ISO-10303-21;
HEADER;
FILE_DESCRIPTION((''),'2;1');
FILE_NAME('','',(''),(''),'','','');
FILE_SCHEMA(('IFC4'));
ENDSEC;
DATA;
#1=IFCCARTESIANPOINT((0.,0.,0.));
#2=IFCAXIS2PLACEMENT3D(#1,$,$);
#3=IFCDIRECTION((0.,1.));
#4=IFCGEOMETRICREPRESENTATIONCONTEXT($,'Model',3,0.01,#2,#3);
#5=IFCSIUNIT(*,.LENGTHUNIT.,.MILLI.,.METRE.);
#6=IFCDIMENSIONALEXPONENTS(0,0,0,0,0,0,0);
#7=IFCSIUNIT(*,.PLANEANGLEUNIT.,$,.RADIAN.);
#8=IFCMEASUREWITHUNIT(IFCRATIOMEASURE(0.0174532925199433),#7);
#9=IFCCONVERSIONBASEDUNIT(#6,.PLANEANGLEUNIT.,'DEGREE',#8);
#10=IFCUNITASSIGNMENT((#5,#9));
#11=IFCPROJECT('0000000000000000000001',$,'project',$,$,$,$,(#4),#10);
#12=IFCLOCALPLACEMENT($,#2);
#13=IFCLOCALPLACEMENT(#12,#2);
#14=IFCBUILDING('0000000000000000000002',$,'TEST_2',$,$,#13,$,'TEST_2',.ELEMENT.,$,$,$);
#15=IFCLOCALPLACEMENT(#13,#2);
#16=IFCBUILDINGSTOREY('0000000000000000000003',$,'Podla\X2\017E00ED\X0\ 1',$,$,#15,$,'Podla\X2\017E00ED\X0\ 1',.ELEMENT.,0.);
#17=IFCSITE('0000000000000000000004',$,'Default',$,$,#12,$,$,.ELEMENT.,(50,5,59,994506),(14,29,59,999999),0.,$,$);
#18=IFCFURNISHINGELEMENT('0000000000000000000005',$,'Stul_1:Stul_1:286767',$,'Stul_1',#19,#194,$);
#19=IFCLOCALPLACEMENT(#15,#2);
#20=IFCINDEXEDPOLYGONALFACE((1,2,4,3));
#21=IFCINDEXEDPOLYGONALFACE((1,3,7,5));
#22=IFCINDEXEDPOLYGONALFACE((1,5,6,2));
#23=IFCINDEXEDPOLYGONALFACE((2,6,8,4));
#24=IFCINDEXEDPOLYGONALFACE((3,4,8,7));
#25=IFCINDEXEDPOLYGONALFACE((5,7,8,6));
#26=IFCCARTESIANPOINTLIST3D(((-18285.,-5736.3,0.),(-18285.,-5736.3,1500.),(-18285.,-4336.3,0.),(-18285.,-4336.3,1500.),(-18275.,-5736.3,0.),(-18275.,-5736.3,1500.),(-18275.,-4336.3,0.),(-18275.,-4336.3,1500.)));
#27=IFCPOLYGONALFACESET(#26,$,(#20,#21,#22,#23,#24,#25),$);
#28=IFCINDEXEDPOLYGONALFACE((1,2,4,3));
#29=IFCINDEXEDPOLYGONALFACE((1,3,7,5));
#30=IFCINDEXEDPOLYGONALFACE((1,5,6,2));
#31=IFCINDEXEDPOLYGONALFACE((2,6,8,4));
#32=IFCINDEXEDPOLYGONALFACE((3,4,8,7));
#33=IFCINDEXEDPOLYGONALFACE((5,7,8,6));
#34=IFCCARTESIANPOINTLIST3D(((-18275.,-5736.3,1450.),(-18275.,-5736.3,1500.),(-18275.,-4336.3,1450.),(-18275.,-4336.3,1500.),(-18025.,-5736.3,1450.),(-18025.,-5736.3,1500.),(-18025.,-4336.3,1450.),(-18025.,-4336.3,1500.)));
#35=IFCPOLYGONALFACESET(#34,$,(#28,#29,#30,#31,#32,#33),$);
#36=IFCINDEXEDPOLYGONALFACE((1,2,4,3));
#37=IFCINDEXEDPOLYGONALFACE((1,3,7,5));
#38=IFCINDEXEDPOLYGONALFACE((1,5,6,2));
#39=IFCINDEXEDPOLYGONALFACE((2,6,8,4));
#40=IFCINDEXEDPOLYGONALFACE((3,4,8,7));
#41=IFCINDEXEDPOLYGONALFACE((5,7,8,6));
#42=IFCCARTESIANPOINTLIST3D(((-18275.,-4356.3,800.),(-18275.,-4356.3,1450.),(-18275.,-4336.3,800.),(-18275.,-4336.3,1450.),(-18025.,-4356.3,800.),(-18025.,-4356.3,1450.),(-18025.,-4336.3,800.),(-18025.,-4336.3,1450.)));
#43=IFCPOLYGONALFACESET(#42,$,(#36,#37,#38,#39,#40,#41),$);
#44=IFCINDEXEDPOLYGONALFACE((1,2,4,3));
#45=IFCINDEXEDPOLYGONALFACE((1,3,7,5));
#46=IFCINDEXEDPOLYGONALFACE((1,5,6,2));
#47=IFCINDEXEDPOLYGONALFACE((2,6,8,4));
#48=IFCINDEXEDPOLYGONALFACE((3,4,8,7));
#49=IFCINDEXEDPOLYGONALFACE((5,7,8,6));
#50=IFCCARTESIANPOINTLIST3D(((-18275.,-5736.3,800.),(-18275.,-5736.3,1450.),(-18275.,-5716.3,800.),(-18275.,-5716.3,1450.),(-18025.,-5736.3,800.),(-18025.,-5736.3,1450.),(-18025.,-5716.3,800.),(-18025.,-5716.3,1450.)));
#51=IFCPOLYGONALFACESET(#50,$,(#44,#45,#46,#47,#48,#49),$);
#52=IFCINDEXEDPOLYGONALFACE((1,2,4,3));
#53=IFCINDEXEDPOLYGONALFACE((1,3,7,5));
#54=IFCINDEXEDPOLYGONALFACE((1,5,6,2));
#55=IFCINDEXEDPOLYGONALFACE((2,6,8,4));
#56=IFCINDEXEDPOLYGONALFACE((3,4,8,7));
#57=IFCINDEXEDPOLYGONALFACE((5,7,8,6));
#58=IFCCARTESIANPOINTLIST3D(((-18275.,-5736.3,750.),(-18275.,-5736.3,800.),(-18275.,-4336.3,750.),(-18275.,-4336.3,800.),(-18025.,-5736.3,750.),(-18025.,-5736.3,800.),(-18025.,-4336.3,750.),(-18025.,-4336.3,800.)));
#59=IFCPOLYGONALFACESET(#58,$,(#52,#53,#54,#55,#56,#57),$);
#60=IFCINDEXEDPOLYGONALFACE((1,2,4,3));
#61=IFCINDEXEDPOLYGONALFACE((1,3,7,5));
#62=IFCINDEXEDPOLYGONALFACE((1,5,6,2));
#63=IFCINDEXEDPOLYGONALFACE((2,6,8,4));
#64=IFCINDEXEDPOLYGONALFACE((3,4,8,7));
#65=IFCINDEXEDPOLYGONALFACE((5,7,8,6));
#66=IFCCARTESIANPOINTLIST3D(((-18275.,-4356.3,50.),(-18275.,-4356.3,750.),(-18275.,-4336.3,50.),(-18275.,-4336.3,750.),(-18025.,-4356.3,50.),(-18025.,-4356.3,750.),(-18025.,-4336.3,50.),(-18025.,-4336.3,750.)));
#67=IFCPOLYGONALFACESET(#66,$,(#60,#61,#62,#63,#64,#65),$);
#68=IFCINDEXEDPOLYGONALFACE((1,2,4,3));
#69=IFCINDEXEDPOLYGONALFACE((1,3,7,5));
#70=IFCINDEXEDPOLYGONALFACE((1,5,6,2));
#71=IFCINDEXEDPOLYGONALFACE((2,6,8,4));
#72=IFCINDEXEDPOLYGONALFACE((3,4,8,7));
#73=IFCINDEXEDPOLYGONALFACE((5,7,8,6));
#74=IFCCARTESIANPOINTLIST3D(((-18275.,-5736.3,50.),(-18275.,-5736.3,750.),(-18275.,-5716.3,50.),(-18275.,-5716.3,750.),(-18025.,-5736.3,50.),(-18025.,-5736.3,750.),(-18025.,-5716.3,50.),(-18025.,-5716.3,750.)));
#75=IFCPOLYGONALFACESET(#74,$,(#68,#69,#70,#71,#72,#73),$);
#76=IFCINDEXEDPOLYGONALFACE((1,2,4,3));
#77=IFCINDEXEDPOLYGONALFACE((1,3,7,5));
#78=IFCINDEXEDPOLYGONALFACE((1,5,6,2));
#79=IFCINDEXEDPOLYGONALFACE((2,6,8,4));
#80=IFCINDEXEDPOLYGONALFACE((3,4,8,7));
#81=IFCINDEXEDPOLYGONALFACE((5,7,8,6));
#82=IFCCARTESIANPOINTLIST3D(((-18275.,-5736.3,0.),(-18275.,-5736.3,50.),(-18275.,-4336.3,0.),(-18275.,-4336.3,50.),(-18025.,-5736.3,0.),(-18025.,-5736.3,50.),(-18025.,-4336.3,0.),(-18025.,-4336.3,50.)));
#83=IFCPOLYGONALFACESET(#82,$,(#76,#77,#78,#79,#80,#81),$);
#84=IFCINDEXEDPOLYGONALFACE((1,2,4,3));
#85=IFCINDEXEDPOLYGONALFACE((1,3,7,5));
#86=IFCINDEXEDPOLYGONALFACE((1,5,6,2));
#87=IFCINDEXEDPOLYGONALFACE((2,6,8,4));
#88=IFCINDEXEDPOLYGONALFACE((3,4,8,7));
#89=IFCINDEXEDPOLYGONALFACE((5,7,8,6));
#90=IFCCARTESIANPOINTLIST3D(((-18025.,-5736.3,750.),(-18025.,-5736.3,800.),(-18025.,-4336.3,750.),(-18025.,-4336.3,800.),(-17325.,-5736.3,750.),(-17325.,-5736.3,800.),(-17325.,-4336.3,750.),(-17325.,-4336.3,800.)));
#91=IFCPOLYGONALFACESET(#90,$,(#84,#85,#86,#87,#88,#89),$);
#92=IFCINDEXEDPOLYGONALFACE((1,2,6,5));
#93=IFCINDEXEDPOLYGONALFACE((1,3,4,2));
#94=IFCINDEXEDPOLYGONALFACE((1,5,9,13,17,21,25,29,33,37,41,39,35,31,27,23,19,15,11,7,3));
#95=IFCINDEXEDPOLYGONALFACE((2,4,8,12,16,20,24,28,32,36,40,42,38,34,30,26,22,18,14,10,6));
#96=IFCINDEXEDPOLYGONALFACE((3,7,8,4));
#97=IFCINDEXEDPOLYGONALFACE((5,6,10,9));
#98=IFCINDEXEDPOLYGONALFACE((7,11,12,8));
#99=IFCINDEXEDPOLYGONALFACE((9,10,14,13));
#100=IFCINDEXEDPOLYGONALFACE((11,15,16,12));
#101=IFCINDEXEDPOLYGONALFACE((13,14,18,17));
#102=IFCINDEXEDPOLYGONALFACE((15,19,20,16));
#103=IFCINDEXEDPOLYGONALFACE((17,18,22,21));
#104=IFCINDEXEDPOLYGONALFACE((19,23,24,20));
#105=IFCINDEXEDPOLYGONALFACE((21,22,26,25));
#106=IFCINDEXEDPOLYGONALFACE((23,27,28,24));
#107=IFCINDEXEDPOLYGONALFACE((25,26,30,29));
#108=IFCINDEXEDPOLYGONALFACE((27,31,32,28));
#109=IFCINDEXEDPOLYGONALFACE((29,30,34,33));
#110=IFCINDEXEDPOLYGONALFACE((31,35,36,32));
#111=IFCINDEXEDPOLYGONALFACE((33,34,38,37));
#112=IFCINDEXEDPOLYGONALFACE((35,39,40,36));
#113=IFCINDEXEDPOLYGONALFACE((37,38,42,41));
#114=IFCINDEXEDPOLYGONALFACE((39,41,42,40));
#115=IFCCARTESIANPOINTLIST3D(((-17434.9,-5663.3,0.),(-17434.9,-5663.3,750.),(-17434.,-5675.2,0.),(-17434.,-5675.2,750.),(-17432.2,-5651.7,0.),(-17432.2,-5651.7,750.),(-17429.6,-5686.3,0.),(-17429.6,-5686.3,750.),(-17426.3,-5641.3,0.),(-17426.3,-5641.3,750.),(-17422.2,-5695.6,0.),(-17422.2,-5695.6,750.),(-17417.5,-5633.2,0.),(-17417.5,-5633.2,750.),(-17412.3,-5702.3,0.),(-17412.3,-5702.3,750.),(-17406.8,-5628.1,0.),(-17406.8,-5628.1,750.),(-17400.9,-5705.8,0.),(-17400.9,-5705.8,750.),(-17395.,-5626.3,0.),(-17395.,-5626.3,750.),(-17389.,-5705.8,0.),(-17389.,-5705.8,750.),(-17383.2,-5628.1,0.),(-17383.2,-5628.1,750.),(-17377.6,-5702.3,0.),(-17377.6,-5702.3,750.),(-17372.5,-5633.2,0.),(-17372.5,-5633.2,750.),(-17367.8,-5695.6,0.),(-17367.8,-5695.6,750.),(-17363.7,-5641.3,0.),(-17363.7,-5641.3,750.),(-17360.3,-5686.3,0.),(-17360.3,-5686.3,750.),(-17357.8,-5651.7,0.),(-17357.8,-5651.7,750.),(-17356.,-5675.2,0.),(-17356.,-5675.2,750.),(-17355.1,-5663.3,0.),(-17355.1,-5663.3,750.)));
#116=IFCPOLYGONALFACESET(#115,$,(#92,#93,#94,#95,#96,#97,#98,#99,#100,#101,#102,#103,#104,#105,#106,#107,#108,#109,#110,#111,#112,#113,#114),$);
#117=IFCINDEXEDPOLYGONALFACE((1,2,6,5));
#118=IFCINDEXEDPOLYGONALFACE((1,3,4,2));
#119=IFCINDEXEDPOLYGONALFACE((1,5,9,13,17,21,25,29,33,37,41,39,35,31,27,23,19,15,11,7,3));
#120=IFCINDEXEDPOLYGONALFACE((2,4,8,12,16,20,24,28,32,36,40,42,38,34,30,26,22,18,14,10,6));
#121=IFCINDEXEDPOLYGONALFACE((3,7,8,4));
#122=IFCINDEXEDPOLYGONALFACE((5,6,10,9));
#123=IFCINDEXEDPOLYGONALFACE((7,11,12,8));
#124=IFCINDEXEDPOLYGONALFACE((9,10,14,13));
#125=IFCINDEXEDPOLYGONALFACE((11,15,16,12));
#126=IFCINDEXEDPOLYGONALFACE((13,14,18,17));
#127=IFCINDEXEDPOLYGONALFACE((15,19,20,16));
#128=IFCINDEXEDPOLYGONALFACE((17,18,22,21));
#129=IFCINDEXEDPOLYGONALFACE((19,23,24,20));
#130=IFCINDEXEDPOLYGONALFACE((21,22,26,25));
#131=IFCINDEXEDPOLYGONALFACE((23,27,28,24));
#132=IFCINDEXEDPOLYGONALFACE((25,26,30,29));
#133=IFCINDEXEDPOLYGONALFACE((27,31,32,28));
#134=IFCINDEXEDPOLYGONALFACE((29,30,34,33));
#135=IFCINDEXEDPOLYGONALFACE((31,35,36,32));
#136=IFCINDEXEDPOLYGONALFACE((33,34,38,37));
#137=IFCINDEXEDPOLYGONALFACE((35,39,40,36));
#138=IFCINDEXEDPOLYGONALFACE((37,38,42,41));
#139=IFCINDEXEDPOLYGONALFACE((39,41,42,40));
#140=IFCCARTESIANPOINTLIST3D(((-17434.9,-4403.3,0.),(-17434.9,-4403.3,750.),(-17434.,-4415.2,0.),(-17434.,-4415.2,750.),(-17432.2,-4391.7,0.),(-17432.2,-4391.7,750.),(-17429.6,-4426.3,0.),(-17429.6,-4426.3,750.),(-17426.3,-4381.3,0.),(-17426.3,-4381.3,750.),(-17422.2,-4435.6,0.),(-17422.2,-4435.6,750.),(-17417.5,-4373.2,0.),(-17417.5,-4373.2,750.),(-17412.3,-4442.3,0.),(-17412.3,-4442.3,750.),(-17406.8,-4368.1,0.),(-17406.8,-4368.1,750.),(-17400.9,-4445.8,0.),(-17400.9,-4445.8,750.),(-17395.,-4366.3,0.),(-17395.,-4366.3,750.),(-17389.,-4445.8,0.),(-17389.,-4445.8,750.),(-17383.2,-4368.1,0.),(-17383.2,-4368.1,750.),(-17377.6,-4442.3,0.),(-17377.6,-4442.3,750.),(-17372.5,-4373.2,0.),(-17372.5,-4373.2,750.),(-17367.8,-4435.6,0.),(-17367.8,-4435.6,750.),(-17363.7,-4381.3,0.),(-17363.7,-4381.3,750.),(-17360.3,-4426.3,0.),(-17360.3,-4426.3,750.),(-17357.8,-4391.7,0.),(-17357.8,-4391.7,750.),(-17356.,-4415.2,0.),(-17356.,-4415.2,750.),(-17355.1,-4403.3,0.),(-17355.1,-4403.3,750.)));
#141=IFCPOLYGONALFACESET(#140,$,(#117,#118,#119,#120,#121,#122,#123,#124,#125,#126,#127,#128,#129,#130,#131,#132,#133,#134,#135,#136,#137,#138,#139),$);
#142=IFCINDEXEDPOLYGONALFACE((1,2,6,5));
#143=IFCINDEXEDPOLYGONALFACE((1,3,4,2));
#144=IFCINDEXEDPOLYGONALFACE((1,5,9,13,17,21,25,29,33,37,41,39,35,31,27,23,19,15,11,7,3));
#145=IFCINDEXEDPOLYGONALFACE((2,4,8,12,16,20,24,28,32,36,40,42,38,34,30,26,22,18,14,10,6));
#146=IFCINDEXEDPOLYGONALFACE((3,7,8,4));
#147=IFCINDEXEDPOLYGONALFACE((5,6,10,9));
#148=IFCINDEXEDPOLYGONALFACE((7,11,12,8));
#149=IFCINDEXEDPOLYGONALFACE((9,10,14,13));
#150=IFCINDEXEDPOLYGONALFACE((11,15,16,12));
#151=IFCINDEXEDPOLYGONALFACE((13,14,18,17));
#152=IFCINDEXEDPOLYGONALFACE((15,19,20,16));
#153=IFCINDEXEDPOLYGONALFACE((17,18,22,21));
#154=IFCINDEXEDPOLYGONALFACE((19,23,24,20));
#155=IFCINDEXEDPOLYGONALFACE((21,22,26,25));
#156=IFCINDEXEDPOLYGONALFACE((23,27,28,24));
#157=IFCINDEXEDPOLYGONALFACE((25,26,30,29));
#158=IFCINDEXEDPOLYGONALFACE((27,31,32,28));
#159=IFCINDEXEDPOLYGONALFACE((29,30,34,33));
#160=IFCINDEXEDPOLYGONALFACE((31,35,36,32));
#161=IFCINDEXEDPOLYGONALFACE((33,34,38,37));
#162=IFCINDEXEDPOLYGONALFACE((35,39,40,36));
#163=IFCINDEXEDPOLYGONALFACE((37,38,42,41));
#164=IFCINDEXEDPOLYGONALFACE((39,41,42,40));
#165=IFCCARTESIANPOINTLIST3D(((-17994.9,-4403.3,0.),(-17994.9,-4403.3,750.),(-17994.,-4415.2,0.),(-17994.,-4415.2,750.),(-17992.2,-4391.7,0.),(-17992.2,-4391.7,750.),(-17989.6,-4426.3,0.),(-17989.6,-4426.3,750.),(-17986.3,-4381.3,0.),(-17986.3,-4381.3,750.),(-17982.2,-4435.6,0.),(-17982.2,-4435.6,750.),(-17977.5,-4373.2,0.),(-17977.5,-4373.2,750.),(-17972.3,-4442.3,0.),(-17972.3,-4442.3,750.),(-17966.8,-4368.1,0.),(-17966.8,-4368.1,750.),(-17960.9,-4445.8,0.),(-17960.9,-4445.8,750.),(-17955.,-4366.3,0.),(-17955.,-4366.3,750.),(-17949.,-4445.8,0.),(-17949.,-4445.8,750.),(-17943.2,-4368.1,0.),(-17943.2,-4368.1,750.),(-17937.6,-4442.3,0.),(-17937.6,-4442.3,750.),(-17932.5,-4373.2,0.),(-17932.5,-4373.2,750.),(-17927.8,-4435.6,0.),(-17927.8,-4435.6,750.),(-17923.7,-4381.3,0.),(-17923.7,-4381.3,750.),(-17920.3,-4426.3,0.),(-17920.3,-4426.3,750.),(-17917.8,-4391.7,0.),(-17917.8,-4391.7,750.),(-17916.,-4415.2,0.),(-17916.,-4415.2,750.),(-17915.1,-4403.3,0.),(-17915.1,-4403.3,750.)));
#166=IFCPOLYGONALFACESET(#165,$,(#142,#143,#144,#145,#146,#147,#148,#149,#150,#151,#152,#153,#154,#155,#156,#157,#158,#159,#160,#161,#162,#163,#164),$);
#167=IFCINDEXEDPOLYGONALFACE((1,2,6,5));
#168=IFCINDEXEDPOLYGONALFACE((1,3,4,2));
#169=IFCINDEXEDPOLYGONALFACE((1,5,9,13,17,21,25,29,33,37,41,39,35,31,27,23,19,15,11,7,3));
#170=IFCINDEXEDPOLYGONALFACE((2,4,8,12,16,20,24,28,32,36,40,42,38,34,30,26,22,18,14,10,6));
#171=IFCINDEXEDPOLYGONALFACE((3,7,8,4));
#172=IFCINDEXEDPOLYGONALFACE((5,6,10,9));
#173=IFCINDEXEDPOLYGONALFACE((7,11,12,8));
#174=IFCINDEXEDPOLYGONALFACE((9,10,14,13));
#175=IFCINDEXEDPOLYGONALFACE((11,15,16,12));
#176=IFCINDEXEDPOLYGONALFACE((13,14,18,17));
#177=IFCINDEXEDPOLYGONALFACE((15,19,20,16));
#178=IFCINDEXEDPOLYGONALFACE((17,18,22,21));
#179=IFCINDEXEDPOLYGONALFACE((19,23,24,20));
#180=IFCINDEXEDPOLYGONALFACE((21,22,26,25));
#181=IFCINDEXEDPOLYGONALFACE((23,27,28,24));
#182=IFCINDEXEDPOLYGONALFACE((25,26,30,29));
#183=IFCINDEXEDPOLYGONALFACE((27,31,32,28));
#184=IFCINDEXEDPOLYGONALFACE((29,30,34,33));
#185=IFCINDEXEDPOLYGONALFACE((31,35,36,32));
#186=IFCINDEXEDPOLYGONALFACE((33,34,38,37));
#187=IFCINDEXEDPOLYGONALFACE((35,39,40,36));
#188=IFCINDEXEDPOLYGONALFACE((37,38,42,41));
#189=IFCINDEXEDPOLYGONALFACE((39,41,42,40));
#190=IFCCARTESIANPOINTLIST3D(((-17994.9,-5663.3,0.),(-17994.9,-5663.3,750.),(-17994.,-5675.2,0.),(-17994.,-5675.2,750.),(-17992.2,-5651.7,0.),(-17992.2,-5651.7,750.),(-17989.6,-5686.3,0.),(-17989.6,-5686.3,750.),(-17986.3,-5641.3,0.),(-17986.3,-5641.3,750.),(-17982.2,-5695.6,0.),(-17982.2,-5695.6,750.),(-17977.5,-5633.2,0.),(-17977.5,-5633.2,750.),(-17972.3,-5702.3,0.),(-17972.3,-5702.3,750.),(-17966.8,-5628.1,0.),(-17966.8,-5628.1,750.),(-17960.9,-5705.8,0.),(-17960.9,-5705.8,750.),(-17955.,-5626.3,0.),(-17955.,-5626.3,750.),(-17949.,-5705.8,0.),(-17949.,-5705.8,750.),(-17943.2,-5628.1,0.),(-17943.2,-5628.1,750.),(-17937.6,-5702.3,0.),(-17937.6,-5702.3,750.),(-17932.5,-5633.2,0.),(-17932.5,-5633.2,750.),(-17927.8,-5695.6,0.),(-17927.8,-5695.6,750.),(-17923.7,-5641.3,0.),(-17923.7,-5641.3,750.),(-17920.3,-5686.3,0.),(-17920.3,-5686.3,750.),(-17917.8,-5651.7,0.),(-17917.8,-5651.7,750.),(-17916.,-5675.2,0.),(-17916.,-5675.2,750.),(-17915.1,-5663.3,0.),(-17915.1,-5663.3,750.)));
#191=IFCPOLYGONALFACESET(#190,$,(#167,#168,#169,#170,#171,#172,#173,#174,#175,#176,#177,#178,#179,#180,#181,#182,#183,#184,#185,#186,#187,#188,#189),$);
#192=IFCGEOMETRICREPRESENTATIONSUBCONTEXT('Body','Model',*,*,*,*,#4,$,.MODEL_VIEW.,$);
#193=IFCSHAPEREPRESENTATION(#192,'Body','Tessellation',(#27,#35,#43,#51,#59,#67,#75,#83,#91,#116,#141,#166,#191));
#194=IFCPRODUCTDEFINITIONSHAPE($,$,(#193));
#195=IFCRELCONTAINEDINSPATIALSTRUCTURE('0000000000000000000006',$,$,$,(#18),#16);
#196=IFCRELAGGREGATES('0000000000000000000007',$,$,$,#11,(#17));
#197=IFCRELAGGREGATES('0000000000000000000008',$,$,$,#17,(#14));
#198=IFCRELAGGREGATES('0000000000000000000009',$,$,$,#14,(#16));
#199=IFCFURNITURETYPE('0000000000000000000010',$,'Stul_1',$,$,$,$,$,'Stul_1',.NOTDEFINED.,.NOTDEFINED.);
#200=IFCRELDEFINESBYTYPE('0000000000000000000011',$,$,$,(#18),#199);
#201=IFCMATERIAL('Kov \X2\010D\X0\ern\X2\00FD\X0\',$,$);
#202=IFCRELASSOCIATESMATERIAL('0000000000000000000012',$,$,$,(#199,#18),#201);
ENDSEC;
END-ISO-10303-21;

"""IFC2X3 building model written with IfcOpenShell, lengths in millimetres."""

from ifc_helpers import new_model, entity, si_unit, converted_unit, direction, frame, frame_2d, origin, origin_2d_with_axis, place, context, subcontext, project, spatial, rectangle, circle, extrude, source, transform, mapped, material, type_object, type_shapes, element, save


model = new_model("IFC2X3")

# Units and contexts
model_context = context("Model", 3, precision=0.01, world=origin(), true_north=direction((0.0, 1.0)))
body_context = subcontext(model_context, "Body", "Model", "MODEL_VIEW")
ifc_project = project(units=[si_unit("LENGTHUNIT", "METRE", prefix="MILLI"), converted_unit("PLANEANGLEUNIT", "DEGREE", entity("IfcRatioMeasure", 0.0174532925199433), si_unit("PLANEANGLEUNIT", "RADIAN"), dimensions=[0, 0, 0, 0, 0, 0, 0])], contexts=[model_context])

# Site, building, storey
site_placement = place(None, origin())
site = spatial("IfcSite", under=ifc_project, at=site_placement, Name="Default", CompositionType="ELEMENT", RefLatitude=(50, 5, 59, 994506), RefLongitude=(14, 29, 59, 999999), RefElevation=0.0)
building_placement = place(site_placement, origin())
building = spatial("IfcBuilding", under=site, at=building_placement, Name="TEST_2", LongName="TEST_2", CompositionType="ELEMENT")
storey_placement = place(building_placement, origin())
storey = spatial("IfcBuildingStorey", under=building, at=storey_placement, Name="Podlaží 1", LongName="Podlaží 1", CompositionType="ELEMENT", Elevation=0.0)

# Furnishing element
ifc_material_1 = material(Name="Kov černý")
furniture_type = type_object("IfcFurnitureType", Name="Stul_1", ElementType="Stul_1", material=ifc_material_1)
shared_shape_1 = source(origin(), body_context, "Body", "SweptSolid", [
    extrude(rectangle(XDim=1400.0, YDim=10.0, at=origin_2d_with_axis()), frame((0.0, 605.0, 0.0), z_axis=(0.0, 0.0, 1.0), x_axis=(-1.0, 0.0, 0.0)), (0.0, 0.0, 1.0), 1500.0),
    extrude(rectangle(XDim=1400.0, YDim=250.0, at=frame_2d((0.0, 0.0), x_axis=(1.0, 0.0))), frame((0.0, 475.0, 1450.0), z_axis=(0.0, 0.0, 1.0), x_axis=(-1.0, 0.0, 0.0)), (0.0, 0.0, 1.0), 50.0),
    extrude(rectangle(XDim=20.0, YDim=250.0, at=origin_2d_with_axis()), frame((690.0, 475.0, 800.0), z_axis=(0.0, 0.0, 1.0), x_axis=(-1.0, 0.0, 0.0)), (0.0, 0.0, 1.0), 650.0),
    extrude(rectangle(XDim=20.0, YDim=250.0, at=frame_2d((0.0, 0.0), x_axis=(1.0, 0.0))), frame((-690.0, 475.0, 800.0), z_axis=(0.0, 0.0, 1.0), x_axis=(-1.0, 0.0, 0.0)), (0.0, 0.0, 1.0), 650.0),
    extrude(rectangle(XDim=1400.0, YDim=250.0, at=origin_2d_with_axis()), frame((0.0, 475.0, 750.0), z_axis=(0.0, 0.0, 1.0), x_axis=(-1.0, 0.0, 0.0)), (0.0, 0.0, 1.0), 50.0),
    extrude(rectangle(XDim=20.0, YDim=250.0, at=origin_2d_with_axis()), frame((690.0, 475.0, 50.0), z_axis=(0.0, 0.0, 1.0), x_axis=(-1.0, 0.0, 0.0)), (0.0, 0.0, 1.0), 700.0),
    extrude(rectangle(XDim=20.0, YDim=250.0, at=frame_2d((0.0, 0.0), x_axis=(1.0, 0.0))), frame((-690.0, 475.0, 50.0), z_axis=(0.0, 0.0, 1.0), x_axis=(-1.0, 0.0, 0.0)), (0.0, 0.0, 1.0), 700.0),
    extrude(rectangle(XDim=1400.0, YDim=250.0, at=origin_2d_with_axis()), frame((0.0, 475.0, 0.0), z_axis=(0.0, 0.0, 1.0), x_axis=(-1.0, 0.0, 0.0)), (0.0, 0.0, 1.0), 50.0),
    extrude(rectangle(XDim=1400.0, YDim=700.0, at=origin_2d_with_axis()), frame((0.0, 0.0, 750.0), z_axis=(0.0, 0.0, 1.0), x_axis=(-1.0, 0.0, 0.0)), (0.0, 0.0, 1.0), 50.0),
    extrude(circle(Radius=40.0, at=frame_2d((0.0, 0.0), x_axis=(1.0, 0.0))), frame((-630.0, -280.0, 0.0)), (0.0, 0.0, 1.0), 750.0),
    extrude(circle(Radius=40.0, at=frame_2d((0.0, 0.0), x_axis=(1.0, 0.0))), frame((630.0, -280.0, 0.0)), (0.0, 0.0, 1.0), 750.0),
    extrude(circle(Radius=40.0, at=frame_2d((0.0, 0.0), x_axis=(1.0, 0.0))), frame((630.0, 280.0, 0.0)), (0.0, 0.0, 1.0), 750.0),
    extrude(circle(Radius=40.0, at=frame_2d((0.0, 0.0), x_axis=(1.0, 0.0))), frame((-630.0, 280.0, 0.0)), (0.0, 0.0, 1.0), 750.0),
])
type_shapes(furniture_type, [shared_shape_1])
for number, where, z_axis, x_axis, name in (
    (1, (-17675.0, -5036.3, 0.0), (0.0, 0.0, 1.0), (0.0, 1.0, 0.0), "Stul_1:Stul_1:286767"),
):
    element("IfcFurnishingElement", number, at=place(storey_placement, frame(where, z_axis=z_axis, x_axis=x_axis)), inside=storey, type_object=furniture_type, material=ifc_material_1, Name=name, ObjectType="Stul_1", context=body_context, shape_type="MappedRepresentation", body=[
        mapped(shared_shape_1, transform((0.0, 0.0, 0.0), scale=1.0)),
    ])

save(model, "model.ifc")
